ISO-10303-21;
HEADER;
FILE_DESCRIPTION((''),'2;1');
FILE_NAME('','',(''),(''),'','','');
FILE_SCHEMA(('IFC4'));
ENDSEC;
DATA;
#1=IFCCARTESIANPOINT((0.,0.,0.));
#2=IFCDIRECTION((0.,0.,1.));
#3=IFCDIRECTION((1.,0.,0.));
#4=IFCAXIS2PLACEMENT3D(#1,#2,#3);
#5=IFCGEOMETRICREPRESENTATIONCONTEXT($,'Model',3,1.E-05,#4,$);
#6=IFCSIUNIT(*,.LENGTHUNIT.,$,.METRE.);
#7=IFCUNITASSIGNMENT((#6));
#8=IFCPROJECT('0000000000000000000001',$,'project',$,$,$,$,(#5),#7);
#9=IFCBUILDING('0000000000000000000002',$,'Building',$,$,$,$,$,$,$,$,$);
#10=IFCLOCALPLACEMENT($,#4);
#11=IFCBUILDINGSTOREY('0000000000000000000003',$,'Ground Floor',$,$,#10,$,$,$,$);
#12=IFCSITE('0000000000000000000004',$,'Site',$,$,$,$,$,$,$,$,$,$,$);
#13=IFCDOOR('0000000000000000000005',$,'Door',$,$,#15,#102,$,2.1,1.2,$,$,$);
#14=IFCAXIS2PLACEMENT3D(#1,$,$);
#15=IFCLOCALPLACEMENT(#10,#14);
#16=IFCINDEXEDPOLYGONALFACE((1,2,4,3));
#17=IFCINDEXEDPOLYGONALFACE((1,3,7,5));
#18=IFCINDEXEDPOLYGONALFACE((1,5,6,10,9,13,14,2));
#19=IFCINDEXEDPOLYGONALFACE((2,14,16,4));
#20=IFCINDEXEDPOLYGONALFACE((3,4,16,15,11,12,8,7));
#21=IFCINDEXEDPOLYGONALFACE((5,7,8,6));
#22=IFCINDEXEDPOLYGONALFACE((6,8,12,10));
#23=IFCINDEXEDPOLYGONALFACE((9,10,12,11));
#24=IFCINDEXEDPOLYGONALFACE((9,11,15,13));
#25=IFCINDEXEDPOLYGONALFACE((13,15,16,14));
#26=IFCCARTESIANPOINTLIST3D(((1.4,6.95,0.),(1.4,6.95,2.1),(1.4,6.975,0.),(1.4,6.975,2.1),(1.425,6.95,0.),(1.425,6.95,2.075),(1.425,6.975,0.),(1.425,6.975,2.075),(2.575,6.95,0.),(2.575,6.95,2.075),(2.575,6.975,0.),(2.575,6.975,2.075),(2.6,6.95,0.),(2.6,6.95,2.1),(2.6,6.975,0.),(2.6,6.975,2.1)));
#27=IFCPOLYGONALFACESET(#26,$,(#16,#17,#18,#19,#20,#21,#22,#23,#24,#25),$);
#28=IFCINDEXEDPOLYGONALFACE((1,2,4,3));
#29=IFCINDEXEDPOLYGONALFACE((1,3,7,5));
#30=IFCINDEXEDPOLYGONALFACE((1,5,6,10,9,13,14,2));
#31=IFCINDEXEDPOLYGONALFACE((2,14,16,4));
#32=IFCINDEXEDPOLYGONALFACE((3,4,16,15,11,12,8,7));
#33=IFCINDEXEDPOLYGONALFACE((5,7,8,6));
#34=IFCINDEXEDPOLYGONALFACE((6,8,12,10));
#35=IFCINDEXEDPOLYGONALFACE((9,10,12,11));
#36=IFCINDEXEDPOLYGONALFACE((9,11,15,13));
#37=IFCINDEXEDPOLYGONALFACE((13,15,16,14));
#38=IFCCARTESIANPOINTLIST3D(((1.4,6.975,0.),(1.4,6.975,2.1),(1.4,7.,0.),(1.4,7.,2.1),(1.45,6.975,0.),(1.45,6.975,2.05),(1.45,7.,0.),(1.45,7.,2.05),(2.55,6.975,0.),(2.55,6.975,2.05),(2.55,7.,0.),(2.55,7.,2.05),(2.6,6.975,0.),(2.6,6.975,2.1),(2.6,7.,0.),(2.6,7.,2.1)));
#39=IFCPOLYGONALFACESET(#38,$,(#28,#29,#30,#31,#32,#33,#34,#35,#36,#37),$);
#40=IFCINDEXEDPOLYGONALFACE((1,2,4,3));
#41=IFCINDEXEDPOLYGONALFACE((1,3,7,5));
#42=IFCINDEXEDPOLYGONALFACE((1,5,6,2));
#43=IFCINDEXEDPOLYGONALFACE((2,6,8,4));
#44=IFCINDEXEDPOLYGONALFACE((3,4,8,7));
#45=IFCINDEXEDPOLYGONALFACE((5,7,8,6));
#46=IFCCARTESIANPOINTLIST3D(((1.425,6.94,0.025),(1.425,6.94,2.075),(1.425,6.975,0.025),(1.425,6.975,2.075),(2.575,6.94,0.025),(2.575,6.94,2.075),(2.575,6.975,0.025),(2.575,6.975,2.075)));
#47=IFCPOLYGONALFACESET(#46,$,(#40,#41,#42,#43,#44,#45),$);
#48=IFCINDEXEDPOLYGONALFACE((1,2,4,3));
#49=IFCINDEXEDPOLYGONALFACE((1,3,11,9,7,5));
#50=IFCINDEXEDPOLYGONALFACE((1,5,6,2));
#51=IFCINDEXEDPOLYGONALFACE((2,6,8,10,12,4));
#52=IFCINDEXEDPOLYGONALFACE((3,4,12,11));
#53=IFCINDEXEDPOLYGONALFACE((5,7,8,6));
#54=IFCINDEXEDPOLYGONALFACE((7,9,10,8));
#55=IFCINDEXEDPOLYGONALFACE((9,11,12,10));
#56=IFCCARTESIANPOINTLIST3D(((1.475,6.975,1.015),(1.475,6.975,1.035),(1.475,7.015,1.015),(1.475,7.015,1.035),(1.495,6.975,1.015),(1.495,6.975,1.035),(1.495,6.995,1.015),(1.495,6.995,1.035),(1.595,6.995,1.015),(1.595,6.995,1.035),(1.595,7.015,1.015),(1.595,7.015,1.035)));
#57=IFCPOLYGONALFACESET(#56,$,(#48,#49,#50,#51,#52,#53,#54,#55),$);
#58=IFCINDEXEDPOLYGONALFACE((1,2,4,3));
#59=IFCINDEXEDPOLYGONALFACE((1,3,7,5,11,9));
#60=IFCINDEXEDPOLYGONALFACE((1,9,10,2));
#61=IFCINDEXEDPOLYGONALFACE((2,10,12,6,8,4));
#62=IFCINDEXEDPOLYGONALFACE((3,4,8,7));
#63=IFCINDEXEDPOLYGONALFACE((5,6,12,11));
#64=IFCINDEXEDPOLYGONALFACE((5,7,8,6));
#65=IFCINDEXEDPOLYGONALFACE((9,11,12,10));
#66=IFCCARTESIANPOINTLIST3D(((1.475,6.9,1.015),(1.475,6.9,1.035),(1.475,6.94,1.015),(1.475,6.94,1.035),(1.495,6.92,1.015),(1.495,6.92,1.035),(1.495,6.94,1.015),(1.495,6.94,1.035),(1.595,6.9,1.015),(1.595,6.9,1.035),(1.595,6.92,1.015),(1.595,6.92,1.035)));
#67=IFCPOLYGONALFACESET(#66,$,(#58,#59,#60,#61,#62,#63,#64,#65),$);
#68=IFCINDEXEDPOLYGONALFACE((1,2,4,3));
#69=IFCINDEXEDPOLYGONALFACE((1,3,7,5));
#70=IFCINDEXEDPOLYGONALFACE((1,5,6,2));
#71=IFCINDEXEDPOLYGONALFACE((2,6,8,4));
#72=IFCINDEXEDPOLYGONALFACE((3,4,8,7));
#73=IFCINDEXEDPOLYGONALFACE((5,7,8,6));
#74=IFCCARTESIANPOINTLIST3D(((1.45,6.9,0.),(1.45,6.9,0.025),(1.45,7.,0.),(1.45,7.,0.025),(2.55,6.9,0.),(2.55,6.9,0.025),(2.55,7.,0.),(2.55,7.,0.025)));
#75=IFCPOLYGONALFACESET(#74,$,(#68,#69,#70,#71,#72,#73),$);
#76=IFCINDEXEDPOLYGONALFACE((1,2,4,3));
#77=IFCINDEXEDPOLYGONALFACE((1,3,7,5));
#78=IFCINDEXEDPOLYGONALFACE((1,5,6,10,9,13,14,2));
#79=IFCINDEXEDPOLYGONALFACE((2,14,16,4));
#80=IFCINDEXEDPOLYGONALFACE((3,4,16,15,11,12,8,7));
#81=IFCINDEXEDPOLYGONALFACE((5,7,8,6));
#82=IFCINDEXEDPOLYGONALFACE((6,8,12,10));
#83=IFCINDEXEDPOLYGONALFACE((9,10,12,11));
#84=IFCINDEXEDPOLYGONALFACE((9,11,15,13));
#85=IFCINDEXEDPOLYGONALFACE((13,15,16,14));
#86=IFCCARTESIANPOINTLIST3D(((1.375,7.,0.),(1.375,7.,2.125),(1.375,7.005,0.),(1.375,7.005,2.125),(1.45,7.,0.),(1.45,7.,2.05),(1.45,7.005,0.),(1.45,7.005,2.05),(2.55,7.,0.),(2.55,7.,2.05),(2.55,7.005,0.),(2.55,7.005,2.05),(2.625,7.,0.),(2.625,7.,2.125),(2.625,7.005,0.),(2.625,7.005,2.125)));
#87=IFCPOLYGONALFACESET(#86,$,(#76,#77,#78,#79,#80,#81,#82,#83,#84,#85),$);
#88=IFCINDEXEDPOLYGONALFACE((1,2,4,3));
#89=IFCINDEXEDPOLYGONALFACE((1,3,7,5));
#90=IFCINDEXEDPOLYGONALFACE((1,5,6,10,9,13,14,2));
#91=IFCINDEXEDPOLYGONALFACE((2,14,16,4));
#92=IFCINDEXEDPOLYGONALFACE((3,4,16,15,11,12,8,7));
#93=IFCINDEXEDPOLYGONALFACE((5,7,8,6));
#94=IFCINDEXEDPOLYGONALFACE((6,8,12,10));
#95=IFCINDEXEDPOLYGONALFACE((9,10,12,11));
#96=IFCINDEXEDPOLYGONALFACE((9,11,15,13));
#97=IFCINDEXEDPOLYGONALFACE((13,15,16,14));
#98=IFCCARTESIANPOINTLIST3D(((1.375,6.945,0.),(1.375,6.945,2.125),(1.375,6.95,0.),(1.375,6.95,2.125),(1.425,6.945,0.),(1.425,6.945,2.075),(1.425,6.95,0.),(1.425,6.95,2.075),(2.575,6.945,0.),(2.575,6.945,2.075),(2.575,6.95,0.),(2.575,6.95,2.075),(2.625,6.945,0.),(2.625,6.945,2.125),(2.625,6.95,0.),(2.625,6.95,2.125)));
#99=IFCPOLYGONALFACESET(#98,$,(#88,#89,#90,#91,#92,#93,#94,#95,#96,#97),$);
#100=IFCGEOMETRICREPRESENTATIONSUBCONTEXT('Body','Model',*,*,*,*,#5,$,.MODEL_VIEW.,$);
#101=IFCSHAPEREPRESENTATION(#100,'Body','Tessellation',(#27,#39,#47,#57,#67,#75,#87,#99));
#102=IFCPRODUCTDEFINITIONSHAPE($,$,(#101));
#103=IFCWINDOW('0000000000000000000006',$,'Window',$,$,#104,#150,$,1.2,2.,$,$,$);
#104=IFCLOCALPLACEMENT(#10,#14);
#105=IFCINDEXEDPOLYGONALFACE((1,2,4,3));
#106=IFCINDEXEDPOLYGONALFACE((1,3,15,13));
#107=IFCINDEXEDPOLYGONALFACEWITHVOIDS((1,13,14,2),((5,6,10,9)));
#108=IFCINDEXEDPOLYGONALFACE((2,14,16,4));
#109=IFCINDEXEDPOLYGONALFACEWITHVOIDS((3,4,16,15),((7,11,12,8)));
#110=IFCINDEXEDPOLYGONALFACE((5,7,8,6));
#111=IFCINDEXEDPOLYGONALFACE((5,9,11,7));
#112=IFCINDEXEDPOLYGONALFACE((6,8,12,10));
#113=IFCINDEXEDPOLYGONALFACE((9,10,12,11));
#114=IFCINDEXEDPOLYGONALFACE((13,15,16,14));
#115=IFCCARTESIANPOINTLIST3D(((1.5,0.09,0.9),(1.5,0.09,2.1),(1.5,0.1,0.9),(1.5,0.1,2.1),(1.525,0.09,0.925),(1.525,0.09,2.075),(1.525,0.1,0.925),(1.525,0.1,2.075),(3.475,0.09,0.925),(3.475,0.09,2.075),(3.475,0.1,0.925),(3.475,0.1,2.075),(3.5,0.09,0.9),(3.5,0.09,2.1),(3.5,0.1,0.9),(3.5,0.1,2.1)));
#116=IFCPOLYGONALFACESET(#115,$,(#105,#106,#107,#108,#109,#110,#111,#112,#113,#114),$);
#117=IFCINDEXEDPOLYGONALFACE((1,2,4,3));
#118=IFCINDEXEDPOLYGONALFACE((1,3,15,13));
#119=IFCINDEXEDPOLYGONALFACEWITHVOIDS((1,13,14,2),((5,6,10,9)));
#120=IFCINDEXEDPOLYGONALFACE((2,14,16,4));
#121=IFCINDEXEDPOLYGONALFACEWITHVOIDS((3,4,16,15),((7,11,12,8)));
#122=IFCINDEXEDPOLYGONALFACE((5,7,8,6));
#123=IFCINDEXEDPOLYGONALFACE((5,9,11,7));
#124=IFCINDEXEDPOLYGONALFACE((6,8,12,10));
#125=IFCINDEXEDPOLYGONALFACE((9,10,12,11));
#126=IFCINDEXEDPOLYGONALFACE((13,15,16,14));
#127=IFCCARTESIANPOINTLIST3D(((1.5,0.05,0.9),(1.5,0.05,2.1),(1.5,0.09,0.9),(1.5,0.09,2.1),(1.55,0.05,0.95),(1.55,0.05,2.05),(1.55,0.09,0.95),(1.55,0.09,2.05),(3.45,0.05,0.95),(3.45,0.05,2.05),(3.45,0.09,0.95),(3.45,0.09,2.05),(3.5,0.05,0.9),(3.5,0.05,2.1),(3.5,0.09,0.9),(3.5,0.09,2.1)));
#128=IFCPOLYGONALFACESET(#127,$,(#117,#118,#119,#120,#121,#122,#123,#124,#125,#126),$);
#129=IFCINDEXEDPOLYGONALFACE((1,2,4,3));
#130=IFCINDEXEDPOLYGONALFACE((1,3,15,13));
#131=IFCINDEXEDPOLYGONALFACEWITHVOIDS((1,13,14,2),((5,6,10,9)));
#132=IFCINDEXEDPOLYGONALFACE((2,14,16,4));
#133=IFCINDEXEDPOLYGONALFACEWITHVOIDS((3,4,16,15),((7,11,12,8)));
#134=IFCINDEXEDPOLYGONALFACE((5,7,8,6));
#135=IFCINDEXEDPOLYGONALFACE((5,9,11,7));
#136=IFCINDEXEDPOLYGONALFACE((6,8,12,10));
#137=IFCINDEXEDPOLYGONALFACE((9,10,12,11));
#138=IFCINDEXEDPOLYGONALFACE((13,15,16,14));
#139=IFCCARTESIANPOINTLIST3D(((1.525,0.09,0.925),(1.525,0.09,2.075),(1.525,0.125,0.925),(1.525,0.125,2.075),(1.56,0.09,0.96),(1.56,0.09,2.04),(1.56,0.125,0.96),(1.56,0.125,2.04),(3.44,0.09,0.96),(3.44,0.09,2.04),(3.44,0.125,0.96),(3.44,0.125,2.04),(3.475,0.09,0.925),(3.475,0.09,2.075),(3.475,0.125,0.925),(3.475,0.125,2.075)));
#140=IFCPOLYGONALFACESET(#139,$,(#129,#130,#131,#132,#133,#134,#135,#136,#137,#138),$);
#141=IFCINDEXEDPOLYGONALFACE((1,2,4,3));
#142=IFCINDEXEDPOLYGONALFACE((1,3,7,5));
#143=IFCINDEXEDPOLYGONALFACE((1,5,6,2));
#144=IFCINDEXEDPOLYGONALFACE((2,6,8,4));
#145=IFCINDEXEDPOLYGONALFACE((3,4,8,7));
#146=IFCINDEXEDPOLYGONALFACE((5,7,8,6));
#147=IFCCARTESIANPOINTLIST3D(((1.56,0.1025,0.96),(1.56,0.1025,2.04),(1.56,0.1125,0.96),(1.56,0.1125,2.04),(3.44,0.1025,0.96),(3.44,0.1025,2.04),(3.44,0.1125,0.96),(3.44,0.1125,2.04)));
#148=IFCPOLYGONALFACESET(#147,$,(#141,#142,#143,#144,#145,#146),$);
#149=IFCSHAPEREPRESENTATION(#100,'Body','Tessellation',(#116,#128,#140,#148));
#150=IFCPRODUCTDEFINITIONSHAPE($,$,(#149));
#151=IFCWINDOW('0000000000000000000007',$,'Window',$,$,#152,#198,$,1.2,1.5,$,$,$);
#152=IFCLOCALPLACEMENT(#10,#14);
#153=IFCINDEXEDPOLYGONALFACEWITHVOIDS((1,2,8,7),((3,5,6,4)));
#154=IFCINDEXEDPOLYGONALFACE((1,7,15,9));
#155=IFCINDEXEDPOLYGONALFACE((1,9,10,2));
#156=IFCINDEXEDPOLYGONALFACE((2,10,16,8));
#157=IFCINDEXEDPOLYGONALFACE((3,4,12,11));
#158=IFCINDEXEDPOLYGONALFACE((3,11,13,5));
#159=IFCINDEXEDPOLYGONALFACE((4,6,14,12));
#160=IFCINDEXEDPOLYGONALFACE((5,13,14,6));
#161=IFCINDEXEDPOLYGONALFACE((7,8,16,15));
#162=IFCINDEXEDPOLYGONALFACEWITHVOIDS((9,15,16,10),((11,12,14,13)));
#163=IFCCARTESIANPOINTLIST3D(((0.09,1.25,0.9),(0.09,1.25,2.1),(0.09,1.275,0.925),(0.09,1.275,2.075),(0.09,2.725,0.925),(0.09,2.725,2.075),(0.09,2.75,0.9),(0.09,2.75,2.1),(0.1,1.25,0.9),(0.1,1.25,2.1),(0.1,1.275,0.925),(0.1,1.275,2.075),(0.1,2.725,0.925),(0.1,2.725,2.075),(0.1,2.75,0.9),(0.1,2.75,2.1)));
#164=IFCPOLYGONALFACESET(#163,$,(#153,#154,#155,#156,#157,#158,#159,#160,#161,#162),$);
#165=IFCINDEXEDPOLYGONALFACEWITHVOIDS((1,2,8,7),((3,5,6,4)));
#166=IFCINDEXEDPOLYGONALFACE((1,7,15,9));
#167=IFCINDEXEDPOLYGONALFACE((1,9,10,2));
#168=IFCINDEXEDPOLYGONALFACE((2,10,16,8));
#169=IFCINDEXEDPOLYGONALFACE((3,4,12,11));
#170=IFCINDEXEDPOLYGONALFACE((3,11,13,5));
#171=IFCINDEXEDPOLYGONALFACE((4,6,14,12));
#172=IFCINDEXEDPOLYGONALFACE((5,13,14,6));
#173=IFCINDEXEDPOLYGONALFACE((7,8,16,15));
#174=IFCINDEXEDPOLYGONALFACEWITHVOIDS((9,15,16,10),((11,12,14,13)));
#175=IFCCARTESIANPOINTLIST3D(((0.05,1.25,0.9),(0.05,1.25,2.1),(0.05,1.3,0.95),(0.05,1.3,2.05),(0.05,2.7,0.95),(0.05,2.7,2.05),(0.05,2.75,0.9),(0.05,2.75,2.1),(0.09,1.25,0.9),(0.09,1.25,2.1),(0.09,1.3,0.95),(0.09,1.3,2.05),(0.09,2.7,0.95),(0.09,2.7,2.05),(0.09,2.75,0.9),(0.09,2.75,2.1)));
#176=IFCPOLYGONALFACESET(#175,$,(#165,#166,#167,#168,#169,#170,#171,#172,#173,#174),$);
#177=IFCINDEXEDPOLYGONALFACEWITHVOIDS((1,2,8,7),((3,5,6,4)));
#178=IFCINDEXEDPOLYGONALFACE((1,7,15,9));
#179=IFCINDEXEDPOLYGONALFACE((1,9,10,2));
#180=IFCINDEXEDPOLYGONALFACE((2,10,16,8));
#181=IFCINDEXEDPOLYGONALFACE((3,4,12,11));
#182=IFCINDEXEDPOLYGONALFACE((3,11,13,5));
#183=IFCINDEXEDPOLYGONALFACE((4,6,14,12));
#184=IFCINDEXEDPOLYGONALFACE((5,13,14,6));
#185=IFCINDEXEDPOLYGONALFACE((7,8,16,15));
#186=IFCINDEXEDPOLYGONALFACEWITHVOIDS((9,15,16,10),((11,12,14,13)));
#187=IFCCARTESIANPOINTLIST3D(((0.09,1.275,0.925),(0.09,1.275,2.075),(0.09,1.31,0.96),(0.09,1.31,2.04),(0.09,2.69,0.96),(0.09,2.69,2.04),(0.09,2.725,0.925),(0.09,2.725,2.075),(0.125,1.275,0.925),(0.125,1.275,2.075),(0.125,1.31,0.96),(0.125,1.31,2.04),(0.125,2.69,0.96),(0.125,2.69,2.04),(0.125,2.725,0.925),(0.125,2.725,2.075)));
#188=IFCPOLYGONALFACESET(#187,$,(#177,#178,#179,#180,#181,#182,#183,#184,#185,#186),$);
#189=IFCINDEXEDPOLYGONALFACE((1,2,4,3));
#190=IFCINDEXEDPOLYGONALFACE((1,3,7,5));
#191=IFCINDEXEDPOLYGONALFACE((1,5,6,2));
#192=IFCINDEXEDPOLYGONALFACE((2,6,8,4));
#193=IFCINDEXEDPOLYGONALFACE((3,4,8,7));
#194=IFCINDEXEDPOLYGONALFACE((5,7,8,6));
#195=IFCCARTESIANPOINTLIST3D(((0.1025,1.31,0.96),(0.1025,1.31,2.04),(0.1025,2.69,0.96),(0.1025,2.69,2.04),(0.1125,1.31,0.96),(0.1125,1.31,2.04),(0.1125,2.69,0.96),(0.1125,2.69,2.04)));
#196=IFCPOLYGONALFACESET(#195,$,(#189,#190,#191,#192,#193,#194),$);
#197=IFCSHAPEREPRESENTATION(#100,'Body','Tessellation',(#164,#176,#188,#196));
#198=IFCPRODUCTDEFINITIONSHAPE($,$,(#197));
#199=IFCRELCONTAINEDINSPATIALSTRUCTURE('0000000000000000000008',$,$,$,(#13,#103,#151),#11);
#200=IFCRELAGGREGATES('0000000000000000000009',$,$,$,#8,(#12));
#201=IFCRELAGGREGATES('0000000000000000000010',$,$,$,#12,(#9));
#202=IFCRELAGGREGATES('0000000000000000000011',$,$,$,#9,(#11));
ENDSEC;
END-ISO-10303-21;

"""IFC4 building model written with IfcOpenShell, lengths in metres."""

from ifc_helpers import new_model, si_unit, frame, origin_with_axes, place, context, subcontext, project, spatial, line, indexed_curve, outline, extrude, element, save


model = new_model("IFC4")

# Units and contexts
model_context = context("Model", 3, precision=1e-05, world=origin_with_axes())
body_context = subcontext(model_context, "Body", "Model", "MODEL_VIEW")
ifc_project = project(units=[si_unit("LENGTHUNIT", "METRE")], contexts=[model_context])

# Site, building, storey
site = spatial("IfcSite", under=ifc_project, Name="Site")
building = spatial("IfcBuilding", under=site, Name="Building")
storey_placement = place(None, origin_with_axes())
storey = spatial("IfcBuildingStorey", under=building, at=storey_placement, Name="Ground Floor")

# Door
door_1_placement = place(storey_placement, frame((2.6, 7.0, 0.0), z_axis=(0.0, 0.0, 1.0), x_axis=(-1.0, 0.0, 0.0)))
element("IfcDoor", 1, at=door_1_placement, inside=storey, Name="Door", OverallHeight=2.1, OverallWidth=1.2, context=body_context, shape_type="SweptSolid", body=[
    extrude(outline(indexed_curve([(0.0, 0.0), (0.0, 2.1), (1.2, 2.1), (1.2, 0.0), (1.175, 0.0), (1.175, 2.075), (0.025, 2.075), (0.025, 0.0)], segments=[line(1, 2, 3, 4, 5, 6, 7, 8, 1)])), frame((0.0, 0.025, 0.0), z_axis=(0.0, -1.0, 0.0), x_axis=(1.0, 0.0, 0.0)), (0.0, 0.0, -1.0), 0.025),
    extrude(outline(indexed_curve([(0.0, 0.0), (0.0, 2.1), (1.2, 2.1), (1.2, 0.0), (1.15, 0.0), (1.15, 2.05), (0.05, 2.05), (0.05, 0.0)], segments=[line(1, 2, 3, 4, 5, 6, 7, 8, 1)])), frame((0.0, 0.0, 0.0), z_axis=(0.0, -1.0, 0.0), x_axis=(1.0, 0.0, 0.0)), (0.0, 0.0, -1.0), 0.025),
    extrude(outline(indexed_curve([(0.0, 0.0), (1.15, 0.0), (1.15, 0.035), (0.0, 0.035)], segments=[line(1, 2, 3, 4, 1)])), frame((0.025, 0.025, 0.025), z_axis=(0.0, 0.0, 1.0), x_axis=(1.0, 0.0, 0.0)), (0.0, 0.0, 1.0), 2.05),
    extrude(outline(indexed_curve([(0.0, 0.0), (0.0, -0.04), (-0.12, -0.04), (-0.12, -0.02), (-0.02, -0.02), (-0.02, 0.0)], segments=[line(1, 2, 3, 4, 5, 6, 1)])), frame((1.125, 0.025, 1.015), z_axis=(0.0, 0.0, 1.0), x_axis=(1.0, 0.0, 0.0)), (0.0, 0.0, 1.0), 0.02),
    extrude(outline(indexed_curve([(0.0, 0.0), (0.0, 0.04), (-0.12, 0.04), (-0.12, 0.02), (-0.02, 0.02), (-0.02, 0.0)], segments=[line(1, 2, 3, 4, 5, 6, 1)])), frame((1.125, 0.06, 1.015), z_axis=(0.0, 0.0, 1.0), x_axis=(1.0, 0.0, 0.0)), (0.0, 0.0, 1.0), 0.02),
    extrude(outline(indexed_curve([(0.0, 0.0), (1.1, 0.0), (1.1, 0.1), (0.0, 0.1)], segments=[line(1, 2, 3, 4, 1)])), frame((0.05, 0.0, 0.0), z_axis=(0.0, 0.0, 1.0), x_axis=(1.0, 0.0, 0.0)), (0.0, 0.0, 1.0), 0.025),
    extrude(outline(indexed_curve([(0.0, 0.0), (0.0, 2.125), (1.25, 2.125), (1.25, 0.0), (1.175, 0.0), (1.175, 2.05), (0.075, 2.05), (0.075, 0.0)], segments=[line(1, 2, 3, 4, 5, 6, 7, 8, 1)])), frame((-0.025, -0.005, 0.0), z_axis=(0.0, -1.0, 0.0), x_axis=(1.0, 0.0, 0.0)), (0.0, 0.0, -1.0), 0.005),
    extrude(outline(indexed_curve([(0.0, 0.0), (0.0, 2.125), (1.25, 2.125), (1.25, 0.0), (1.2, 0.0), (1.2, 2.075), (0.05, 2.075), (0.05, 0.0)], segments=[line(1, 2, 3, 4, 5, 6, 7, 8, 1)])), frame((-0.025, 0.05, 0.0), z_axis=(0.0, -1.0, 0.0), x_axis=(1.0, 0.0, 0.0)), (0.0, 0.0, -1.0), 0.005),
])

# Windows
window_1_placement = place(storey_placement, frame((1.5, 0.0, 0.9), z_axis=(0.0, 0.0, 1.0), x_axis=(1.0, 0.0, 0.0)))
element("IfcWindow", 2, at=window_1_placement, inside=storey, Name="Window", OverallHeight=1.2, OverallWidth=2.0, context=body_context, shape_type="SweptSolid", body=[
    extrude(outline(indexed_curve([(0.0, 0.0), (2.0, 0.0), (2.0, 1.2), (0.0, 1.2)], segments=[line(1, 2, 3, 4, 1)]), holes=[indexed_curve([(0.025, 0.025), (1.975, 0.025), (1.975, 1.175), (0.025, 1.175)], segments=[line(1, 2, 3, 4, 1)])]), frame((0.0, 0.09, 0.0), z_axis=(0.0, -1.0, 0.0), x_axis=(1.0, 0.0, 0.0)), (0.0, 0.0, -1.0), 0.01),
    extrude(outline(indexed_curve([(0.0, 0.0), (2.0, 0.0), (2.0, 1.2), (0.0, 1.2)], segments=[line(1, 2, 3, 4, 1)]), holes=[indexed_curve([(0.05, 0.05), (1.95, 0.05), (1.95, 1.15), (0.05, 1.15)], segments=[line(1, 2, 3, 4, 1)])]), frame((0.0, 0.05, 0.0), z_axis=(0.0, -1.0, 0.0), x_axis=(1.0, 0.0, 0.0)), (0.0, 0.0, -1.0), 0.04),
    extrude(outline(indexed_curve([(0.0, 0.0), (1.95, 0.0), (1.95, 1.15), (0.0, 1.15)], segments=[line(1, 2, 3, 4, 1)]), holes=[indexed_curve([(0.035, 0.035), (1.915, 0.035), (1.915, 1.115), (0.035, 1.115)], segments=[line(1, 2, 3, 4, 1)])]), frame((0.025, 0.09, 0.025), z_axis=(0.0, -1.0, 0.0), x_axis=(1.0, 0.0, 0.0)), (0.0, 0.0, -1.0), 0.035),
    extrude(outline(indexed_curve([(0.035, 0.035), (1.915, 0.035), (1.915, 1.115), (0.035, 1.115)], segments=[line(1, 2, 3, 4, 1)])), frame((0.025, 0.1025, 0.025), z_axis=(0.0, -1.0, 0.0), x_axis=(1.0, 0.0, 0.0)), (0.0, 0.0, -1.0), 0.01),
])
for number, where, z_axis, x_axis, name in (
    (3, (0.0, 2.75, 0.9), (0.0, 0.0, 1.0), (0.0, -1.0, 0.0), "Window"),
):
    element("IfcWindow", number, at=place(storey_placement, frame(where, z_axis=z_axis, x_axis=x_axis)), inside=storey, Name=name, OverallHeight=1.2, OverallWidth=1.5, context=body_context, shape_type="SweptSolid", body=[
        extrude(outline(indexed_curve([(0.0, 0.0), (1.5, 0.0), (1.5, 1.2), (0.0, 1.2)], segments=[line(1, 2, 3, 4, 1)]), holes=[indexed_curve([(0.025, 0.025), (1.475, 0.025), (1.475, 1.175), (0.025, 1.175)], segments=[line(1, 2, 3, 4, 1)])]), frame((0.0, 0.09, 0.0), z_axis=(0.0, -1.0, 0.0), x_axis=(1.0, 0.0, 0.0)), (0.0, 0.0, -1.0), 0.01),
        extrude(outline(indexed_curve([(0.0, 0.0), (1.5, 0.0), (1.5, 1.2), (0.0, 1.2)], segments=[line(1, 2, 3, 4, 1)]), holes=[indexed_curve([(0.05, 0.05), (1.45, 0.05), (1.45, 1.15), (0.05, 1.15)], segments=[line(1, 2, 3, 4, 1)])]), frame((0.0, 0.05, 0.0), z_axis=(0.0, -1.0, 0.0), x_axis=(1.0, 0.0, 0.0)), (0.0, 0.0, -1.0), 0.04),
        extrude(outline(indexed_curve([(0.0, 0.0), (1.45, 0.0), (1.45, 1.15), (0.0, 1.15)], segments=[line(1, 2, 3, 4, 1)]), holes=[indexed_curve([(0.035, 0.035), (1.415, 0.035), (1.415, 1.115), (0.035, 1.115)], segments=[line(1, 2, 3, 4, 1)])]), frame((0.025, 0.09, 0.025), z_axis=(0.0, -1.0, 0.0), x_axis=(1.0, 0.0, 0.0)), (0.0, 0.0, -1.0), 0.035),
        extrude(outline(indexed_curve([(0.035, 0.035), (1.415, 0.035), (1.415, 1.115), (0.035, 1.115)], segments=[line(1, 2, 3, 4, 1)])), frame((0.025, 0.1025, 0.025), z_axis=(0.0, -1.0, 0.0), x_axis=(1.0, 0.0, 0.0)), (0.0, 0.0, -1.0), 0.01),
    ])

save(model, "model.ifc")
